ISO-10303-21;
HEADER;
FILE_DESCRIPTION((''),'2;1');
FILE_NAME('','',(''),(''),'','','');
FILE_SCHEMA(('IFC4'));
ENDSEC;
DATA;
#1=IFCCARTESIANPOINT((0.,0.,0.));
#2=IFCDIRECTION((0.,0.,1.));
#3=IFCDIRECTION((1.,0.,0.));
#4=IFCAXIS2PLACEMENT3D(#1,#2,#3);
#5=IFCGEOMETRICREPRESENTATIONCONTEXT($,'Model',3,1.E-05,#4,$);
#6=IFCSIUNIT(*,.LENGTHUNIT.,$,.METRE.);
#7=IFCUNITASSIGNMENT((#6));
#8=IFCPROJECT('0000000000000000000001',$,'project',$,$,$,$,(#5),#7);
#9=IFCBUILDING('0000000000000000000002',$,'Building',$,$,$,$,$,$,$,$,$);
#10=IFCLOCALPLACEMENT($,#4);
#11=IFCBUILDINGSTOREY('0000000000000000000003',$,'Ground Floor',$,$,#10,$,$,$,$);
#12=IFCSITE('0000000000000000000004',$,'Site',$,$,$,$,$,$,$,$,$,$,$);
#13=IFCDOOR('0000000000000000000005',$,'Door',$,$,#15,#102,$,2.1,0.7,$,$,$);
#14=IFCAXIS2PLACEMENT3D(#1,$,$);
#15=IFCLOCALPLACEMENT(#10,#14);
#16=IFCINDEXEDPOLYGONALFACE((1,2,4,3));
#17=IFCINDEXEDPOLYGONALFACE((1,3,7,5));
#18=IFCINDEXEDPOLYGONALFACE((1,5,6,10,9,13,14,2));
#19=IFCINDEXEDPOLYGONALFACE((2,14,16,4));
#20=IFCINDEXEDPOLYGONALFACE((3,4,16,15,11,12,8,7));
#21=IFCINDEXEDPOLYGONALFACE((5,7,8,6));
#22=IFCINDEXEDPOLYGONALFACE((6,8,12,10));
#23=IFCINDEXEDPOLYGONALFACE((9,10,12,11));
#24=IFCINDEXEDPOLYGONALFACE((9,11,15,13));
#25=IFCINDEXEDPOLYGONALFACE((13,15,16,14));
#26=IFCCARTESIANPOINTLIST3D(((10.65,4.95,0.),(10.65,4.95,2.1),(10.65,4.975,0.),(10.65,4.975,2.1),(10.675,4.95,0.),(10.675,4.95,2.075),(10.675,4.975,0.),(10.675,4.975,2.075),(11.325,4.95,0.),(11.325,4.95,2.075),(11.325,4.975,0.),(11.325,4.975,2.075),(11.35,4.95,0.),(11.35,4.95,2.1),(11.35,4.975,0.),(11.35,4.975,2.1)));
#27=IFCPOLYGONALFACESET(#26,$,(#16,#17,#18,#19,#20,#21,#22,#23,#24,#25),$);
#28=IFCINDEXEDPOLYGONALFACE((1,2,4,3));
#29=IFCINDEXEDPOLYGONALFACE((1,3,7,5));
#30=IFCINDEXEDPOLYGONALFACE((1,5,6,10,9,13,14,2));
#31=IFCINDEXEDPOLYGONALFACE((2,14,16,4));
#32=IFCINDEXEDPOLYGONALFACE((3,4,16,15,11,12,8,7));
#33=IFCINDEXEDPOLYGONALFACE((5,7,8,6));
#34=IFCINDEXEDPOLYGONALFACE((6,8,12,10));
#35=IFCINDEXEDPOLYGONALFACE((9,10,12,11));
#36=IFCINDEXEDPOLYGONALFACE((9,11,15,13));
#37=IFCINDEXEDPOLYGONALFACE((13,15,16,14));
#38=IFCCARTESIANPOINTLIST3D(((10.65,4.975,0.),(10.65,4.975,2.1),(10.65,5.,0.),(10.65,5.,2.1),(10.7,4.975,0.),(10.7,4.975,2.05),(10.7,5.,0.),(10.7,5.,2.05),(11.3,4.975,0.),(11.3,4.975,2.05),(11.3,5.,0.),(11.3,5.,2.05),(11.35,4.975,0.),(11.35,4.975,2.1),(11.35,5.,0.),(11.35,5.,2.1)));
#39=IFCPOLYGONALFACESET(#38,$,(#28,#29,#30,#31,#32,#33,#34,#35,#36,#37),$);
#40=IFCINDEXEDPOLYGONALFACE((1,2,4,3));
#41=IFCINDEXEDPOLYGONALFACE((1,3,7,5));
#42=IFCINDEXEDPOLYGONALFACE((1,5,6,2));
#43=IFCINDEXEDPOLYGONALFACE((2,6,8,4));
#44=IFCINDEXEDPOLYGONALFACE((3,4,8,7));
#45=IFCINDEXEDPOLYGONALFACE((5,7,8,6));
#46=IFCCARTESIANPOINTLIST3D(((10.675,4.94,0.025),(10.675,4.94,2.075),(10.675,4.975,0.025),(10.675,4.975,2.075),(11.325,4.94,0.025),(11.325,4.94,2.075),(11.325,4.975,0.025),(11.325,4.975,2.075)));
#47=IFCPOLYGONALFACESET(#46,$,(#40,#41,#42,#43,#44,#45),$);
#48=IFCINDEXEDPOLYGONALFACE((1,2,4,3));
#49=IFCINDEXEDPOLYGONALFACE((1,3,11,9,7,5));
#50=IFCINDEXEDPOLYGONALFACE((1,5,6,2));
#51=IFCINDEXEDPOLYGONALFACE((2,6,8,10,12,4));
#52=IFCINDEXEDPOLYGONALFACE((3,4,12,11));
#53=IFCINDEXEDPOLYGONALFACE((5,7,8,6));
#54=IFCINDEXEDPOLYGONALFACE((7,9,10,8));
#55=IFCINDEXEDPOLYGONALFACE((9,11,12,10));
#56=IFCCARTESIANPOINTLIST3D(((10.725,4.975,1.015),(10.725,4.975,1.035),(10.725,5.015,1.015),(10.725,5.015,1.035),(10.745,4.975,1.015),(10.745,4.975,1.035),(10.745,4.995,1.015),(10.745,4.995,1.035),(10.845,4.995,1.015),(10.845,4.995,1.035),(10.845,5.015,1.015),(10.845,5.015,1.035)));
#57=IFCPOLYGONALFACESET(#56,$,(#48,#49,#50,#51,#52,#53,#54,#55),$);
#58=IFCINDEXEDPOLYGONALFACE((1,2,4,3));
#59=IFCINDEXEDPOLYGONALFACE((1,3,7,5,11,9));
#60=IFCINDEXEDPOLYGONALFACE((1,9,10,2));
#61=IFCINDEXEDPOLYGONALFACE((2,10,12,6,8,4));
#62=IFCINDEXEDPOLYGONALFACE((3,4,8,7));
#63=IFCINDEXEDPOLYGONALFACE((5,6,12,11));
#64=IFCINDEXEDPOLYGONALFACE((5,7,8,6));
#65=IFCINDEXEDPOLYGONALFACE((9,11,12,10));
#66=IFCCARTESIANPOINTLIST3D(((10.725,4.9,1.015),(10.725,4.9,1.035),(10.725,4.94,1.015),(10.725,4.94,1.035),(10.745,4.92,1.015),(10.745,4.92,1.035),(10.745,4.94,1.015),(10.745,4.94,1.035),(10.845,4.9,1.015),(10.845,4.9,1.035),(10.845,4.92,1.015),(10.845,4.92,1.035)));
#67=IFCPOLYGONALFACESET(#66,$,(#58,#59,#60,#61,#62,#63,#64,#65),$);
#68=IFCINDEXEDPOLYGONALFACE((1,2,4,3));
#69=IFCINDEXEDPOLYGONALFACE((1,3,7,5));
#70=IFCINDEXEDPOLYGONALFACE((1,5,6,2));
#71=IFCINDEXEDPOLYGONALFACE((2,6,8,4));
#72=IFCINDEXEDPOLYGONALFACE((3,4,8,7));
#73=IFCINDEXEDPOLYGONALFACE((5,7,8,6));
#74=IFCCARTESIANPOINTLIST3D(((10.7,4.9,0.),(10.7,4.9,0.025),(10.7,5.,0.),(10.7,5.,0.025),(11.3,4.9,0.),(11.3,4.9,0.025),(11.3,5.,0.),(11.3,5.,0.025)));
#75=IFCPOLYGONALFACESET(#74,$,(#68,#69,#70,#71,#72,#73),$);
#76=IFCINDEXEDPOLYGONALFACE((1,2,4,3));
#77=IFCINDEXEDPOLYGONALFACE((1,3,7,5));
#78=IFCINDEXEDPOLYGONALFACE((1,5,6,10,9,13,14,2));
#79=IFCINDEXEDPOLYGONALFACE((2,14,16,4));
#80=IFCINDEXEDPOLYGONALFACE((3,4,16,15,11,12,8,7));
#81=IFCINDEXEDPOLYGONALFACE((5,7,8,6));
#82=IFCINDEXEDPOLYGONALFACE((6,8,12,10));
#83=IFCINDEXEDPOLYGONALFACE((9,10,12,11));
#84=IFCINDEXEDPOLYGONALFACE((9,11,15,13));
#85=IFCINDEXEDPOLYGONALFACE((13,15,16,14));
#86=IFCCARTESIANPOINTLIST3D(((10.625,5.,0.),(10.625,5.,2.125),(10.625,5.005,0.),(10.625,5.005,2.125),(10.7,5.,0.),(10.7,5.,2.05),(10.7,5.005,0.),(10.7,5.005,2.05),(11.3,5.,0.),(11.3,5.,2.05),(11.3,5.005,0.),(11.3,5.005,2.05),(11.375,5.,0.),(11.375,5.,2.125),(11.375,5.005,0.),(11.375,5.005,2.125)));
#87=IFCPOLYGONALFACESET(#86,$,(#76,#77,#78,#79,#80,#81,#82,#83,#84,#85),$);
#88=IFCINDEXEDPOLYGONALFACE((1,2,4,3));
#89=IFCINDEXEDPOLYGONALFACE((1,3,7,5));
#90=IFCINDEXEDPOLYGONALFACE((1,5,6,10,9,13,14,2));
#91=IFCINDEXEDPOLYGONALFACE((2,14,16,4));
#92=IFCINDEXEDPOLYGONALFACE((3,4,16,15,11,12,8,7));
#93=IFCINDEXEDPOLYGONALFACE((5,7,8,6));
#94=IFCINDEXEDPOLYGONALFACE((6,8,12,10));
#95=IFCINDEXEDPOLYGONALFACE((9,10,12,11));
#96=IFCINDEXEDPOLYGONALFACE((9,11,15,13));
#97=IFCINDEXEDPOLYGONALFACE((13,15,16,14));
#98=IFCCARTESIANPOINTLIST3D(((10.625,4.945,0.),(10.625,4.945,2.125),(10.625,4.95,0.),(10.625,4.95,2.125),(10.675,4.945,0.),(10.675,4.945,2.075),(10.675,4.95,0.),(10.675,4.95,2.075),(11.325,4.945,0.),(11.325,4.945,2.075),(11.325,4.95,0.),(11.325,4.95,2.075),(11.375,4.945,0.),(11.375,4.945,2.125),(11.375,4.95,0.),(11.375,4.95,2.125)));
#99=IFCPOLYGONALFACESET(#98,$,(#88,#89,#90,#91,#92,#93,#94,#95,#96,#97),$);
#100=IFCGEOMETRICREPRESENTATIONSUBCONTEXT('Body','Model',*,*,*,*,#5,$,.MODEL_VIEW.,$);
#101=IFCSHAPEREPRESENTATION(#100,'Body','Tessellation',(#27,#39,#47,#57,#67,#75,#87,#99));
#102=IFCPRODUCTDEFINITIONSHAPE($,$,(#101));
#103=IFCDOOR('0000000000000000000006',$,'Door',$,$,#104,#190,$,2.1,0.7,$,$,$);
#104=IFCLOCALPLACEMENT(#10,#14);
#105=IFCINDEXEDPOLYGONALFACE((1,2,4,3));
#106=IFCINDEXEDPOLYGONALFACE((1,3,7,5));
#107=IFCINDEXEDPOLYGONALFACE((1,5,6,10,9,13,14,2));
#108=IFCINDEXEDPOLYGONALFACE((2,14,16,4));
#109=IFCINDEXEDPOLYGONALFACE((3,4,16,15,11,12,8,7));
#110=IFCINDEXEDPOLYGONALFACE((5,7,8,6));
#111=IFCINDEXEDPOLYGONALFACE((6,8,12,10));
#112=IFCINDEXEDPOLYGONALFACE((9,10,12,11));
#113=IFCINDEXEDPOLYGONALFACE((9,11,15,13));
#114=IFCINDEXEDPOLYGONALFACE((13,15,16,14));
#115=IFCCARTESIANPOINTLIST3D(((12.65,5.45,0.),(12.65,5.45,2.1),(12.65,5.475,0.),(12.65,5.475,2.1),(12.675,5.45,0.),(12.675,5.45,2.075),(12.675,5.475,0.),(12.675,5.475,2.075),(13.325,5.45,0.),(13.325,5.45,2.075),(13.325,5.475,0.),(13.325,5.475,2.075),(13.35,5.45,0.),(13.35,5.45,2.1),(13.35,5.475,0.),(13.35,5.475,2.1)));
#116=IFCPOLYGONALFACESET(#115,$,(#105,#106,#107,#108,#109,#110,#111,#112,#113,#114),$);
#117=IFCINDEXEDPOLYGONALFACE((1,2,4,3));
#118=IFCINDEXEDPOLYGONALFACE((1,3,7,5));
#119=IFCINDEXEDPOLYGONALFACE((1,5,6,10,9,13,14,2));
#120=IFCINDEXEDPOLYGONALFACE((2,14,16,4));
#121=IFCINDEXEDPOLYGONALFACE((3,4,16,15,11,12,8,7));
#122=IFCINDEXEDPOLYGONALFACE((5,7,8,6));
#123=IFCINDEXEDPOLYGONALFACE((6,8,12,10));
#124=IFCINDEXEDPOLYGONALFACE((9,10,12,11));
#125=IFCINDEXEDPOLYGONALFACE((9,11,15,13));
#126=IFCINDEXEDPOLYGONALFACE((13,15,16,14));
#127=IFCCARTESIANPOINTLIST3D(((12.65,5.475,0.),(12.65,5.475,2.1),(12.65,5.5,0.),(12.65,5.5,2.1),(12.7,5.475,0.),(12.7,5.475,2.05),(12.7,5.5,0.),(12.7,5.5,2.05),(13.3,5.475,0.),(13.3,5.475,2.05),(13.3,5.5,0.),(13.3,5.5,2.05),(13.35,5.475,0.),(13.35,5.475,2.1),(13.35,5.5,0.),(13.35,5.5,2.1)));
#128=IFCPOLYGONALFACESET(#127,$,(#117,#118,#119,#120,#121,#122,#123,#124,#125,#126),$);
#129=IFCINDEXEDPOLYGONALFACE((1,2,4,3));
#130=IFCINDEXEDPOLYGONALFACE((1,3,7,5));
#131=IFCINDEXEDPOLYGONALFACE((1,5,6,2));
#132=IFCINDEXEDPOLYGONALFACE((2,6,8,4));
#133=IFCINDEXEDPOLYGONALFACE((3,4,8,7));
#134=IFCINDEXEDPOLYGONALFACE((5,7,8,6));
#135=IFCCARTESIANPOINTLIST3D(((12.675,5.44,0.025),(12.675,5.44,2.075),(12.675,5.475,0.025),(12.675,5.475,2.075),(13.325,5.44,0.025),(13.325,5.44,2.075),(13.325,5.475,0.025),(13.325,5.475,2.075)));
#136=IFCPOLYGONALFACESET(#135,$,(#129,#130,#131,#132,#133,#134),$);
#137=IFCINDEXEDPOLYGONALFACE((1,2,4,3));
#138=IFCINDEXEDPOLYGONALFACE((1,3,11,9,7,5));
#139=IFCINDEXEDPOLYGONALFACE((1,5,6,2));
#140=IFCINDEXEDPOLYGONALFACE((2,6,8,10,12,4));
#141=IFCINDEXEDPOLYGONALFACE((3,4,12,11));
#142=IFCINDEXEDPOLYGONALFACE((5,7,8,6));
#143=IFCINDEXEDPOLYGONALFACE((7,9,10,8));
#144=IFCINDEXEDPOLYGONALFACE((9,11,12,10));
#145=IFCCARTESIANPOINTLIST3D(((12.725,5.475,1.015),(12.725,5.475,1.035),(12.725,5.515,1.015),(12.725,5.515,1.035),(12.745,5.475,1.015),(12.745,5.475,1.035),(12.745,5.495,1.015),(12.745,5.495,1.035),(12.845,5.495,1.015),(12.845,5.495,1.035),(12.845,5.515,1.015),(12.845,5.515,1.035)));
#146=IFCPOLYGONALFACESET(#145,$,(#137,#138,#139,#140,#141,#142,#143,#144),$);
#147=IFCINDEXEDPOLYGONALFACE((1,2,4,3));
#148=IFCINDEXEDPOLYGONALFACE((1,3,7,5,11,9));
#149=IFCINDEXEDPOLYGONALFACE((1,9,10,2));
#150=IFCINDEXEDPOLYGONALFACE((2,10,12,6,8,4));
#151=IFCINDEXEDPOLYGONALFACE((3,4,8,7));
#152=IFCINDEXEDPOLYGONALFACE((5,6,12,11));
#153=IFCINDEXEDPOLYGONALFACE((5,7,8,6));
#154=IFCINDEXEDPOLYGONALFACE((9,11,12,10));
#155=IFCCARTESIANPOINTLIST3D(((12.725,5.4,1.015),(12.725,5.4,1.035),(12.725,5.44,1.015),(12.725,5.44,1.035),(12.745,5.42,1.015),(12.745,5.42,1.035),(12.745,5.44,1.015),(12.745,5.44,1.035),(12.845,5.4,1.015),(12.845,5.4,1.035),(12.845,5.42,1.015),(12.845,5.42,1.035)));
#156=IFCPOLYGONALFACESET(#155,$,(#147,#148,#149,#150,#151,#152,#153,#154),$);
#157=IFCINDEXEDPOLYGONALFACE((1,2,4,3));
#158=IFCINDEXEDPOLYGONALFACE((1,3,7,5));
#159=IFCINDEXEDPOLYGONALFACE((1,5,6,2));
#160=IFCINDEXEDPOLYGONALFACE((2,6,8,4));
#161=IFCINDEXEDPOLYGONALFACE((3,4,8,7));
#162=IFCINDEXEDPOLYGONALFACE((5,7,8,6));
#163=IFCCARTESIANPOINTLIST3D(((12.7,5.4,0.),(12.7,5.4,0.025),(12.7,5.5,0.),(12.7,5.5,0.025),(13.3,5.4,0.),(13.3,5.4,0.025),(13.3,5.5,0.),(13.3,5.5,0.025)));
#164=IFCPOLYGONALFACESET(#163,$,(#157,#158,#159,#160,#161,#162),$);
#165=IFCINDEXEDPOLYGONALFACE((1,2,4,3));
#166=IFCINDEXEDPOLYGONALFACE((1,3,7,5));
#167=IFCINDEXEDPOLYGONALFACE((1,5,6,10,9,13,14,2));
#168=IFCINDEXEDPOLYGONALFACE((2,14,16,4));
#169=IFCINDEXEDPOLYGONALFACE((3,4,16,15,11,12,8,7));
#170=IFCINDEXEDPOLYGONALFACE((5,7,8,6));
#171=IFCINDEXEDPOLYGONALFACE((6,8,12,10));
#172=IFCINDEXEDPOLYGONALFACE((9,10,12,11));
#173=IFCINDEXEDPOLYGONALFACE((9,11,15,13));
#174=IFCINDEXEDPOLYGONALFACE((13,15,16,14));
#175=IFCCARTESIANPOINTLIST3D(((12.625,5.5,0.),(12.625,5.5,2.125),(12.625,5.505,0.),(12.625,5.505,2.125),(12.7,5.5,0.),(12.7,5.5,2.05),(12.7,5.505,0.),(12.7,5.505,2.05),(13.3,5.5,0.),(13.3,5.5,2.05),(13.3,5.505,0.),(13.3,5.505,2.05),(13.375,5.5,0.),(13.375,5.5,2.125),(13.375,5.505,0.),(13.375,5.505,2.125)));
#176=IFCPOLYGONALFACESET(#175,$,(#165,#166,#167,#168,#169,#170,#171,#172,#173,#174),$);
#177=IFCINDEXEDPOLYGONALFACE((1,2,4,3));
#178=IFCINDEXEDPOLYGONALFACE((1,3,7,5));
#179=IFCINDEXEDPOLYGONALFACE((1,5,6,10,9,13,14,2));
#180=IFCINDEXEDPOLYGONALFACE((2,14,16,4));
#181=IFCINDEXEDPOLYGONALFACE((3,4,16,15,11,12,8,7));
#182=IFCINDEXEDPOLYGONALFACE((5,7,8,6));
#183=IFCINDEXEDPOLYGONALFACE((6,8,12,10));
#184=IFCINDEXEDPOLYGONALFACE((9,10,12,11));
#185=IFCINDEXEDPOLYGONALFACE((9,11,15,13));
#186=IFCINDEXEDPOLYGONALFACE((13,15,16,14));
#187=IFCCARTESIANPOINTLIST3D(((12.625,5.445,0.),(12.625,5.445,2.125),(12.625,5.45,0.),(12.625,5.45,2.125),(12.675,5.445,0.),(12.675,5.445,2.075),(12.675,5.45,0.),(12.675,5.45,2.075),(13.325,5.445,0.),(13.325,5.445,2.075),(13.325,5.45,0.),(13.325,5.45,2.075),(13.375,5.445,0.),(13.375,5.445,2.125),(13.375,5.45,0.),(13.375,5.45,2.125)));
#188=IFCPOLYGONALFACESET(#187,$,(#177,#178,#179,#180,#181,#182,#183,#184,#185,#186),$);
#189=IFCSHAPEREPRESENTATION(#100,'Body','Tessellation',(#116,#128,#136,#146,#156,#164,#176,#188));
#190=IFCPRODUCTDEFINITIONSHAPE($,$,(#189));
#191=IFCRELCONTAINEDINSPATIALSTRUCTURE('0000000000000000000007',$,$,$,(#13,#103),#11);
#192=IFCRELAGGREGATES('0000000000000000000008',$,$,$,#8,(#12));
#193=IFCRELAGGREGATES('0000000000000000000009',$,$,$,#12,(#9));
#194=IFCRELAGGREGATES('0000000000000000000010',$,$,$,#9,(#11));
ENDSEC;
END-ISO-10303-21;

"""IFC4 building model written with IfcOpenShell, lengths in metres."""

from ifc_helpers import new_model, si_unit, frame, origin_with_axes, place, context, subcontext, project, spatial, line, indexed_curve, outline, extrude, element, save


model = new_model("IFC4")

# Units and contexts
model_context = context("Model", 3, precision=1e-05, world=origin_with_axes())
body_context = subcontext(model_context, "Body", "Model", "MODEL_VIEW")
ifc_project = project(units=[si_unit("LENGTHUNIT", "METRE")], contexts=[model_context])

# Site, building, storey
site = spatial("IfcSite", under=ifc_project, Name="Site")
building = spatial("IfcBuilding", under=site, Name="Building")
storey_placement = place(None, origin_with_axes())
storey = spatial("IfcBuildingStorey", under=building, at=storey_placement, Name="Ground Floor")

# Doors
door_1_placement = place(storey_placement, frame((11.35, 5.0, 0.0), z_axis=(0.0, 0.0, 1.0), x_axis=(-1.0, 0.0, 0.0)))
element("IfcDoor", 1, at=door_1_placement, inside=storey, Name="Door", OverallHeight=2.1, OverallWidth=0.7, context=body_context, shape_type="SweptSolid", body=[
    extrude(outline(indexed_curve([(0.0, 0.0), (0.0, 2.1), (0.7, 2.1), (0.7, 0.0), (0.675, 0.0), (0.675, 2.075), (0.025, 2.075), (0.025, 0.0)], segments=[line(1, 2, 3, 4, 5, 6, 7, 8, 1)])), frame((0.0, 0.025, 0.0), z_axis=(0.0, -1.0, 0.0), x_axis=(1.0, 0.0, 0.0)), (0.0, 0.0, -1.0), 0.025),
    extrude(outline(indexed_curve([(0.0, 0.0), (0.0, 2.1), (0.7, 2.1), (0.7, 0.0), (0.65, 0.0), (0.65, 2.05), (0.05, 2.05), (0.05, 0.0)], segments=[line(1, 2, 3, 4, 5, 6, 7, 8, 1)])), frame((0.0, 0.0, 0.0), z_axis=(0.0, -1.0, 0.0), x_axis=(1.0, 0.0, 0.0)), (0.0, 0.0, -1.0), 0.025),
    extrude(outline(indexed_curve([(0.0, 0.0), (0.65, 0.0), (0.65, 0.035), (0.0, 0.035)], segments=[line(1, 2, 3, 4, 1)])), frame((0.025, 0.025, 0.025), z_axis=(0.0, 0.0, 1.0), x_axis=(1.0, 0.0, 0.0)), (0.0, 0.0, 1.0), 2.05),
    extrude(outline(indexed_curve([(0.0, 0.0), (0.0, -0.04), (-0.12, -0.04), (-0.12, -0.02), (-0.02, -0.02), (-0.02, 0.0)], segments=[line(1, 2, 3, 4, 5, 6, 1)])), frame((0.625, 0.025, 1.015), z_axis=(0.0, 0.0, 1.0), x_axis=(1.0, 0.0, 0.0)), (0.0, 0.0, 1.0), 0.02),
    extrude(outline(indexed_curve([(0.0, 0.0), (0.0, 0.04), (-0.12, 0.04), (-0.12, 0.02), (-0.02, 0.02), (-0.02, 0.0)], segments=[line(1, 2, 3, 4, 5, 6, 1)])), frame((0.625, 0.06, 1.015), z_axis=(0.0, 0.0, 1.0), x_axis=(1.0, 0.0, 0.0)), (0.0, 0.0, 1.0), 0.02),
    extrude(outline(indexed_curve([(0.0, 0.0), (0.6, 0.0), (0.6, 0.1), (0.0, 0.1)], segments=[line(1, 2, 3, 4, 1)])), frame((0.05, 0.0, 0.0), z_axis=(0.0, 0.0, 1.0), x_axis=(1.0, 0.0, 0.0)), (0.0, 0.0, 1.0), 0.025),
    extrude(outline(indexed_curve([(0.0, 0.0), (0.0, 2.125), (0.75, 2.125), (0.75, 0.0), (0.675, 0.0), (0.675, 2.05), (0.075, 2.05), (0.075, 0.0)], segments=[line(1, 2, 3, 4, 5, 6, 7, 8, 1)])), frame((-0.025, -0.005, 0.0), z_axis=(0.0, -1.0, 0.0), x_axis=(1.0, 0.0, 0.0)), (0.0, 0.0, -1.0), 0.005),
    extrude(outline(indexed_curve([(0.0, 0.0), (0.0, 2.125), (0.75, 2.125), (0.75, 0.0), (0.7, 0.0), (0.7, 2.075), (0.05, 2.075), (0.05, 0.0)], segments=[line(1, 2, 3, 4, 5, 6, 7, 8, 1)])), frame((-0.025, 0.05, 0.0), z_axis=(0.0, -1.0, 0.0), x_axis=(1.0, 0.0, 0.0)), (0.0, 0.0, -1.0), 0.005),
])
door_2_placement = place(storey_placement, frame((13.35, 5.5, 0.0), z_axis=(0.0, 0.0, 1.0), x_axis=(-1.0, 0.0, 0.0)))
element("IfcDoor", 2, at=door_2_placement, inside=storey, Name="Door", OverallHeight=2.1, OverallWidth=0.7, context=body_context, shape_type="SweptSolid", body=[
    extrude(outline(indexed_curve([(0.0, 0.0), (0.0, 2.1), (0.7, 2.1), (0.7, 0.0), (0.675, 0.0), (0.675, 2.075), (0.025, 2.075), (0.025, 0.0)], segments=[line(1, 2, 3, 4, 5, 6, 7, 8, 1)])), frame((0.0, 0.025, 0.0), z_axis=(0.0, -1.0, 0.0), x_axis=(1.0, 0.0, 0.0)), (0.0, 0.0, -1.0), 0.025),
    extrude(outline(indexed_curve([(0.0, 0.0), (0.0, 2.1), (0.7, 2.1), (0.7, 0.0), (0.65, 0.0), (0.65, 2.05), (0.05, 2.05), (0.05, 0.0)], segments=[line(1, 2, 3, 4, 5, 6, 7, 8, 1)])), frame((0.0, 0.0, 0.0), z_axis=(0.0, -1.0, 0.0), x_axis=(1.0, 0.0, 0.0)), (0.0, 0.0, -1.0), 0.025),
    extrude(outline(indexed_curve([(0.0, 0.0), (0.65, 0.0), (0.65, 0.035), (0.0, 0.035)], segments=[line(1, 2, 3, 4, 1)])), frame((0.025, 0.025, 0.025), z_axis=(0.0, 0.0, 1.0), x_axis=(1.0, 0.0, 0.0)), (0.0, 0.0, 1.0), 2.05),
    extrude(outline(indexed_curve([(0.0, 0.0), (0.0, -0.04), (-0.12, -0.04), (-0.12, -0.02), (-0.02, -0.02), (-0.02, 0.0)], segments=[line(1, 2, 3, 4, 5, 6, 1)])), frame((0.625, 0.025, 1.015), z_axis=(0.0, 0.0, 1.0), x_axis=(1.0, 0.0, 0.0)), (0.0, 0.0, 1.0), 0.02),
    extrude(outline(indexed_curve([(0.0, 0.0), (0.0, 0.04), (-0.12, 0.04), (-0.12, 0.02), (-0.02, 0.02), (-0.02, 0.0)], segments=[line(1, 2, 3, 4, 5, 6, 1)])), frame((0.625, 0.06, 1.015), z_axis=(0.0, 0.0, 1.0), x_axis=(1.0, 0.0, 0.0)), (0.0, 0.0, 1.0), 0.02),
    extrude(outline(indexed_curve([(0.0, 0.0), (0.6, 0.0), (0.6, 0.1), (0.0, 0.1)], segments=[line(1, 2, 3, 4, 1)])), frame((0.05, 0.0, 0.0), z_axis=(0.0, 0.0, 1.0), x_axis=(1.0, 0.0, 0.0)), (0.0, 0.0, 1.0), 0.025),
    extrude(outline(indexed_curve([(0.0, 0.0), (0.0, 2.125), (0.75, 2.125), (0.75, 0.0), (0.675, 0.0), (0.675, 2.05), (0.075, 2.05), (0.075, 0.0)], segments=[line(1, 2, 3, 4, 5, 6, 7, 8, 1)])), frame((-0.025, -0.005, 0.0), z_axis=(0.0, -1.0, 0.0), x_axis=(1.0, 0.0, 0.0)), (0.0, 0.0, -1.0), 0.005),
    extrude(outline(indexed_curve([(0.0, 0.0), (0.0, 2.125), (0.75, 2.125), (0.75, 0.0), (0.7, 0.0), (0.7, 2.075), (0.05, 2.075), (0.05, 0.0)], segments=[line(1, 2, 3, 4, 5, 6, 7, 8, 1)])), frame((-0.025, 0.05, 0.0), z_axis=(0.0, -1.0, 0.0), x_axis=(1.0, 0.0, 0.0)), (0.0, 0.0, -1.0), 0.005),
])

save(model, "model.ifc")
